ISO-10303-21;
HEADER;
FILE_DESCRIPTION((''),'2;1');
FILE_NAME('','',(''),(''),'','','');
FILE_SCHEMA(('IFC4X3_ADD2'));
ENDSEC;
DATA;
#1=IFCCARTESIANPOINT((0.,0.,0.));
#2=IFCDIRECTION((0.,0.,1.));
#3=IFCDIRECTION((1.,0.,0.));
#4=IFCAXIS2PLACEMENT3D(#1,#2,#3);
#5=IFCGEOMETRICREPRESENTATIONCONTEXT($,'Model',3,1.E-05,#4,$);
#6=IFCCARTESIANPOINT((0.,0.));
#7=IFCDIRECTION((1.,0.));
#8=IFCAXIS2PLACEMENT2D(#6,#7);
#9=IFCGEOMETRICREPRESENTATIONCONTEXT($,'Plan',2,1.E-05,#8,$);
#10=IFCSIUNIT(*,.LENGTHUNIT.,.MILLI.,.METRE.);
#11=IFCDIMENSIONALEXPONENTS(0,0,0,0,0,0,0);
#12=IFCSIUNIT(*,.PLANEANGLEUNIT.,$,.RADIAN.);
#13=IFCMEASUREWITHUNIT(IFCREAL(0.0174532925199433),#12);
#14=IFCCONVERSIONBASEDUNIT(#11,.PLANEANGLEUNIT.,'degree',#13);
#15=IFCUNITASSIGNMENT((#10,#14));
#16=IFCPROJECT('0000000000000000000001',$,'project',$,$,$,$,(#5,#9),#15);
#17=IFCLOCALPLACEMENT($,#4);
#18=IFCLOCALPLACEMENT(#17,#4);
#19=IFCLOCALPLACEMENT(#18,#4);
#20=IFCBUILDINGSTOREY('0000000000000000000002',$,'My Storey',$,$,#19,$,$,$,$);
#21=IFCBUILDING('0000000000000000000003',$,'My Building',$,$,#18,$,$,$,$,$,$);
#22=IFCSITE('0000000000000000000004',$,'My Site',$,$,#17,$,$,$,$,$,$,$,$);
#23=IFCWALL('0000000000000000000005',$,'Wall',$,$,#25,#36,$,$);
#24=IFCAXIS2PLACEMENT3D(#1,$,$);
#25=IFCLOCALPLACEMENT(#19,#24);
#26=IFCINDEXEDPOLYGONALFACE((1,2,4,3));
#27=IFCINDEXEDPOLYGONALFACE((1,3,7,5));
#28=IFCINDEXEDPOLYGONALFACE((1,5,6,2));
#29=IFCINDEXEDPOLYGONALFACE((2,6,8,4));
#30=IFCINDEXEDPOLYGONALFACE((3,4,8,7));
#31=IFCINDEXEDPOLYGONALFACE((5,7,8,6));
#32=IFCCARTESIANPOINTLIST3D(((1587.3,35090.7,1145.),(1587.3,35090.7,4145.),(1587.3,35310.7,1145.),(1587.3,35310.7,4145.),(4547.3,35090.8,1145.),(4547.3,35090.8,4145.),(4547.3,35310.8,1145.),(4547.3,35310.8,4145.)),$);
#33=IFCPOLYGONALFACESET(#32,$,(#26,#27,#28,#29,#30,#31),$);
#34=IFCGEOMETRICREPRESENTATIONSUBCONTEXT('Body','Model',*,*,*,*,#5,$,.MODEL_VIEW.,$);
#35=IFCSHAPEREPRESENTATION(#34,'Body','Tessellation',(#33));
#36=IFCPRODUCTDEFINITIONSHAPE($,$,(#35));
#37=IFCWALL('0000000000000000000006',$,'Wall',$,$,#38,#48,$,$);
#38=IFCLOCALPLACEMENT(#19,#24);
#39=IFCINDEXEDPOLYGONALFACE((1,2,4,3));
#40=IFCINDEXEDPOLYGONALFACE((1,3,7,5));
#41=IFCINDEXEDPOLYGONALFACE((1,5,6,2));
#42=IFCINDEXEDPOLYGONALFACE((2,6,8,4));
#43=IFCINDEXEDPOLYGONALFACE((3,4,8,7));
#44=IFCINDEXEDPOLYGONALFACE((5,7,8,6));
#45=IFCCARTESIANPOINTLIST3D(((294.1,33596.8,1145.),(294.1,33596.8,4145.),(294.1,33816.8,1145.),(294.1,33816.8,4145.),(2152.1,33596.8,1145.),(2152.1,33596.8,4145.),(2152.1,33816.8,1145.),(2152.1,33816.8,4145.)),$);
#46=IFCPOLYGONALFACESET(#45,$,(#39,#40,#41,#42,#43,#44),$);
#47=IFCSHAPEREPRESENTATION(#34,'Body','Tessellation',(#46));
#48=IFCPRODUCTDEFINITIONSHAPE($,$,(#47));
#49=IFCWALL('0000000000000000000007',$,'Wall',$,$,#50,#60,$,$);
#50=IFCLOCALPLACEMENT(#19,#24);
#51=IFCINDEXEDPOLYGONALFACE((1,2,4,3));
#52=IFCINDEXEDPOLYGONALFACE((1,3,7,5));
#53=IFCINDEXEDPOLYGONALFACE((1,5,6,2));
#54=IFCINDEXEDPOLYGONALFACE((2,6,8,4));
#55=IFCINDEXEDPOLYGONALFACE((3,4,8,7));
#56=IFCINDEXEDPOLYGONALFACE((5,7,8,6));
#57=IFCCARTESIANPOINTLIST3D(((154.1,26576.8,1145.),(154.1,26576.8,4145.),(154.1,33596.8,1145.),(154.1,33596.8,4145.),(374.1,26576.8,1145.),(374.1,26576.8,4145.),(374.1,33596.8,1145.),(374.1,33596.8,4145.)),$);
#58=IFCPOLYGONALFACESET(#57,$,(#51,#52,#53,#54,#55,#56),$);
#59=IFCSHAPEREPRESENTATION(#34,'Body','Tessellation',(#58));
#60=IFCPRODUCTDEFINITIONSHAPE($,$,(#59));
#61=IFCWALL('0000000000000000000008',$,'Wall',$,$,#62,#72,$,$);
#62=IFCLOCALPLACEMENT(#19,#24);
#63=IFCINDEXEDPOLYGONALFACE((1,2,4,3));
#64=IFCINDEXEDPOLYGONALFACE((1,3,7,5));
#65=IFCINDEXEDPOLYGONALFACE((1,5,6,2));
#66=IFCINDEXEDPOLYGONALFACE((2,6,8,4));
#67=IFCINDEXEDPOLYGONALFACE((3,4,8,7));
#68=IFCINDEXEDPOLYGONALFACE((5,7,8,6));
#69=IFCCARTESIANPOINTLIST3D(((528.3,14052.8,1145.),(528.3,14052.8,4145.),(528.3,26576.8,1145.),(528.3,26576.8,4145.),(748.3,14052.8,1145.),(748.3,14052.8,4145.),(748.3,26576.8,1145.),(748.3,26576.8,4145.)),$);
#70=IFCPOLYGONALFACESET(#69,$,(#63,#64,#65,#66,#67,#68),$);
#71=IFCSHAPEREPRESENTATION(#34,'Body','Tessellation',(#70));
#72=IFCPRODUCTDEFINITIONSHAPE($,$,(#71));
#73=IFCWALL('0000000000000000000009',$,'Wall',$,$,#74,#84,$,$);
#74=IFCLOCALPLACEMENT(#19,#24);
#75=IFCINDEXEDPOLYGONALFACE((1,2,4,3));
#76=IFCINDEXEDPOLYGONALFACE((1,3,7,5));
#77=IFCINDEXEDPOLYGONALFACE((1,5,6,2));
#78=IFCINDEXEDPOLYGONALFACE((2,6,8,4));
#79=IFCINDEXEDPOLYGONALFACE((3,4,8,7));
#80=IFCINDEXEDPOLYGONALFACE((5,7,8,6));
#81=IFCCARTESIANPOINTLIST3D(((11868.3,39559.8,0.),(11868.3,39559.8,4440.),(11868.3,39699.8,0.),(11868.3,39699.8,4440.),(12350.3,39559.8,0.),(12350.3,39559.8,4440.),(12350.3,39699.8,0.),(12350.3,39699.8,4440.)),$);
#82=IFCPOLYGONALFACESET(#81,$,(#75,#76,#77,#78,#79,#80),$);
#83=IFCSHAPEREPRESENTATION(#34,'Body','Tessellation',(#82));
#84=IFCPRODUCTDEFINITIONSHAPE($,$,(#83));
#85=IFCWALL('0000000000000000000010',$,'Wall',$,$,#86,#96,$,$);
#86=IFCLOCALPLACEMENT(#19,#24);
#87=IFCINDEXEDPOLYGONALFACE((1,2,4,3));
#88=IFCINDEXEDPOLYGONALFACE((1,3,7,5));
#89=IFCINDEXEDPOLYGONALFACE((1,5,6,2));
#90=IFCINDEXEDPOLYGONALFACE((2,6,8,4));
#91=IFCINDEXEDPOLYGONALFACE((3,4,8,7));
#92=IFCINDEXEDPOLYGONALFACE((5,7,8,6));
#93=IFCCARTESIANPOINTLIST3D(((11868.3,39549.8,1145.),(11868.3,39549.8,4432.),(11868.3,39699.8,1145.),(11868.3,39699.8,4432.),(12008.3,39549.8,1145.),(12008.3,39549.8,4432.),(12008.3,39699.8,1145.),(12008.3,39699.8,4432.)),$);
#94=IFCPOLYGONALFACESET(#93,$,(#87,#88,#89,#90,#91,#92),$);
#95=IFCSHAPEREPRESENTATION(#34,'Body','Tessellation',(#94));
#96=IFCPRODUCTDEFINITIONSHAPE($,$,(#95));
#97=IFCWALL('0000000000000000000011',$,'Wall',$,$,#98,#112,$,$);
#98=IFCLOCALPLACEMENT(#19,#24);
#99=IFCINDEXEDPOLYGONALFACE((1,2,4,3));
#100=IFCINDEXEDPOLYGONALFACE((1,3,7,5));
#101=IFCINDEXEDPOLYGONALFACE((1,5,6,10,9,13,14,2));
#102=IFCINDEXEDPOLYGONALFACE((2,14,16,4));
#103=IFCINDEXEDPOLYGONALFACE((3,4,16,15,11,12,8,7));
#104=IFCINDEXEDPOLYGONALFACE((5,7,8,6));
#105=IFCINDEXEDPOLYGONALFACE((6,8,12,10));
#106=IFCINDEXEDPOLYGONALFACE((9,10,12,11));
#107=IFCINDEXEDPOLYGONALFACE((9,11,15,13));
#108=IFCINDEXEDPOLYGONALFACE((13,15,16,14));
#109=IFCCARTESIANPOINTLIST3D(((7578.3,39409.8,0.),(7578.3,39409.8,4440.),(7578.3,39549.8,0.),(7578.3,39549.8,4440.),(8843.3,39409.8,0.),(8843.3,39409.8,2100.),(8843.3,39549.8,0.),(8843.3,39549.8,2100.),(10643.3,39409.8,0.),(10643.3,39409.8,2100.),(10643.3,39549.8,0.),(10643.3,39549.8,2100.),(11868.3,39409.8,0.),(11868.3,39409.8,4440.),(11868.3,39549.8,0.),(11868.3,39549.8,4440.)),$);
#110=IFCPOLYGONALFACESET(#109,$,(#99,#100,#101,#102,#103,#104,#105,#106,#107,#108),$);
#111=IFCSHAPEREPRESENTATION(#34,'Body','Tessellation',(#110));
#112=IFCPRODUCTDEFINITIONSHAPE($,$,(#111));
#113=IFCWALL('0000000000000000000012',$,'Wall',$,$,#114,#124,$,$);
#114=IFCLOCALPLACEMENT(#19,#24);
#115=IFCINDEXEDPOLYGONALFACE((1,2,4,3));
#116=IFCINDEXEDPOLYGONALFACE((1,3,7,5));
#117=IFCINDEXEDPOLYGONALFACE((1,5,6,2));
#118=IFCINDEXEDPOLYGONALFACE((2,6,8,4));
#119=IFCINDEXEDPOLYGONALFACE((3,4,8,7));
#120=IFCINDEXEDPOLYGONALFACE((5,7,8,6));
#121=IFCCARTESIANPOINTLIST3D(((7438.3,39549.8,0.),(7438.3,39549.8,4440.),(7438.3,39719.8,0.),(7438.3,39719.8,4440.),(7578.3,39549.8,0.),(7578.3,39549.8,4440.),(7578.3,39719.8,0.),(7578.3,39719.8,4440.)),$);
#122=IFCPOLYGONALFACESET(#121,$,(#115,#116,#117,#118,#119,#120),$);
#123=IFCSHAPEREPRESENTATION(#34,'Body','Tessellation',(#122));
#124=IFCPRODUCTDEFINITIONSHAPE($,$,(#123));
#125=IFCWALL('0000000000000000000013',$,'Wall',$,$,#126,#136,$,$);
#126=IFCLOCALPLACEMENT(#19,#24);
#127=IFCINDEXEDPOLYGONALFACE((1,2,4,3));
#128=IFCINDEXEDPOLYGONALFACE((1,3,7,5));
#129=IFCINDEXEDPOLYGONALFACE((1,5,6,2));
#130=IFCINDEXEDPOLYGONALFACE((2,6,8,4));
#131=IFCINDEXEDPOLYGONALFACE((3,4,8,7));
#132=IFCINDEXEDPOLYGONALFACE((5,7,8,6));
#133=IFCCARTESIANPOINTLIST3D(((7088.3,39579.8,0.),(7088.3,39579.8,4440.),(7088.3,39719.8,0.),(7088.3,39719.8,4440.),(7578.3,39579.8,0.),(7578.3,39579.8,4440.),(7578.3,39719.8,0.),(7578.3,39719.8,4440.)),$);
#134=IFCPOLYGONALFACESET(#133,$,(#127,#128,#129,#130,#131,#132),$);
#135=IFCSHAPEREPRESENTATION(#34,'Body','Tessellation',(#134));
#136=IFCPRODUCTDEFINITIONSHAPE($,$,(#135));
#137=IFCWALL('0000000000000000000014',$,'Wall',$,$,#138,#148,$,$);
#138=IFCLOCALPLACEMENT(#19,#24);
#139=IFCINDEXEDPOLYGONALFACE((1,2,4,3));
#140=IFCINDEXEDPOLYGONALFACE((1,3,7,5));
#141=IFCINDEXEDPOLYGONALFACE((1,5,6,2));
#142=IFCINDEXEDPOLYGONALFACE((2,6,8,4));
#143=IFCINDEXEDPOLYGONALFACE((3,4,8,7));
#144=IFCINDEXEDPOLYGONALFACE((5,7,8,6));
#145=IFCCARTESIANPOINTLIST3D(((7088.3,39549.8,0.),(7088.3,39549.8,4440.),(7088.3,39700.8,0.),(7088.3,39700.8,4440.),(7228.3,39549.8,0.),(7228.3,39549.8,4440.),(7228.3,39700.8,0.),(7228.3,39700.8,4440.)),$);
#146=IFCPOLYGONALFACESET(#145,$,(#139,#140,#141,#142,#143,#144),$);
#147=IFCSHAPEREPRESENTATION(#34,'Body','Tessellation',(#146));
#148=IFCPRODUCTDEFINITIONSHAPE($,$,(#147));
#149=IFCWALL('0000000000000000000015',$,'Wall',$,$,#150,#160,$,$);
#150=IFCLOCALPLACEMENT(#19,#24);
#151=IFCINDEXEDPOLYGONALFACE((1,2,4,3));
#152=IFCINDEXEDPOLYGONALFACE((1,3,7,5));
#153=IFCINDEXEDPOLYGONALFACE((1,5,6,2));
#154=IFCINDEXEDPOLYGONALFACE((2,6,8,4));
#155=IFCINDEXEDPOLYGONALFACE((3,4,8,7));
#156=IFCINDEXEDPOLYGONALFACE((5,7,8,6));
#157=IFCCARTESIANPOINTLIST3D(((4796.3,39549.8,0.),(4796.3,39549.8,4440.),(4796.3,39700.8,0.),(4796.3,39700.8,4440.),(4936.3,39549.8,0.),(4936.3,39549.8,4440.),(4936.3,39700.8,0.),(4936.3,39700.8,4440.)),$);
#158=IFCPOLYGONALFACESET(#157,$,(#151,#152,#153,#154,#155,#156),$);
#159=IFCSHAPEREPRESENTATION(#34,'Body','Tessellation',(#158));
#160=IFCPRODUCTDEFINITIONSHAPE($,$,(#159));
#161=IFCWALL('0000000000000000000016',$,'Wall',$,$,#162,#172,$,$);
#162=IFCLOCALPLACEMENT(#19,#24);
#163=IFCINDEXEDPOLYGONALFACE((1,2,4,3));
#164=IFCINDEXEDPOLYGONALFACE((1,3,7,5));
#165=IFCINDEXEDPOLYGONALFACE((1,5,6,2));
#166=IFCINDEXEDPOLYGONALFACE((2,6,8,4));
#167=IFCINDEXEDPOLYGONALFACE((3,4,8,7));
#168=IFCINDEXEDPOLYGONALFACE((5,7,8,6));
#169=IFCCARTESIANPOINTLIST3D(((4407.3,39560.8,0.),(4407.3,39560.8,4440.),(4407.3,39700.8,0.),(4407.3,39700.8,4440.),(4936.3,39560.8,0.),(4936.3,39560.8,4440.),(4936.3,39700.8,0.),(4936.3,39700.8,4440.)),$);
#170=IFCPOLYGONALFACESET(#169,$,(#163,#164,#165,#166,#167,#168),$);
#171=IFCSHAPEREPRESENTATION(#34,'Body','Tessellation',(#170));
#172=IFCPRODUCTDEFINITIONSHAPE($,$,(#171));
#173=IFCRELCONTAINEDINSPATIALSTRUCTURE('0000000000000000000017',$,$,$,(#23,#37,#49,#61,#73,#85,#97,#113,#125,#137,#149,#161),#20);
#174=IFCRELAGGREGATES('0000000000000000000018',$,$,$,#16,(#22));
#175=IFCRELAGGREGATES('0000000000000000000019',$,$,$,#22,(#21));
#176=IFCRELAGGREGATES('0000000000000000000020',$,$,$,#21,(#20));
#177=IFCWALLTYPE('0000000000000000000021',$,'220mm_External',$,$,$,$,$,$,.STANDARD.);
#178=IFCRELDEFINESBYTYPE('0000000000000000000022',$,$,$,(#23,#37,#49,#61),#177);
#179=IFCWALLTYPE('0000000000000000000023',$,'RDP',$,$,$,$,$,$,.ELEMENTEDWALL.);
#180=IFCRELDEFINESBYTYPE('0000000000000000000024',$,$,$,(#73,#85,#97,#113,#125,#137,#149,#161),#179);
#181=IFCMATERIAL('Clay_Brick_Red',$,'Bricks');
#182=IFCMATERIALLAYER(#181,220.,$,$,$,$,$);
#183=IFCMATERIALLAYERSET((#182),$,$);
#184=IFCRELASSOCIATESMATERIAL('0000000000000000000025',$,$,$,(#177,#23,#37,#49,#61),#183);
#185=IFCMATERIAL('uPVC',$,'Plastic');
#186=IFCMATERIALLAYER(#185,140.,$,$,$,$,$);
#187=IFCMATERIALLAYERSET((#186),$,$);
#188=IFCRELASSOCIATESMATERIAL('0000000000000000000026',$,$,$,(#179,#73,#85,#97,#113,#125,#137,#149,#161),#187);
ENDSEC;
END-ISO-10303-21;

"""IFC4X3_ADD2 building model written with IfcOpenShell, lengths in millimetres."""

from ifc_helpers import new_model, entity, si_unit, converted_unit, frame, origin_with_axes, origin_2d_with_axis, place, context, subcontext, project, spatial, line, indexed_curve, outline, extrude, material, layer, layer_set, layer_usage, type_object, element, save


model = new_model("IFC4X3_ADD2")

# Units and contexts
model_context = context("Model", 3, precision=1e-05, world=origin_with_axes())
plan_context = context("Plan", 2, precision=1e-05, world=origin_2d_with_axis())
body_context_1 = subcontext(model_context, "Body", "Model", "MODEL_VIEW")
ifc_project = project(units=[si_unit("LENGTHUNIT", "METRE", prefix="MILLI"), converted_unit("PLANEANGLEUNIT", "degree", entity("IfcReal", 0.0174532925199433), si_unit("PLANEANGLEUNIT", "RADIAN"), dimensions=[0, 0, 0, 0, 0, 0, 0])], contexts=[model_context, plan_context])

# Site, building, storey
site_placement = place(None, origin_with_axes())
site = spatial("IfcSite", under=ifc_project, at=site_placement, Name="My Site")
building_placement = place(site_placement, origin_with_axes())
building = spatial("IfcBuilding", under=site, at=building_placement, Name="My Building")
storey_placement = place(building_placement, origin_with_axes())
storey = spatial("IfcBuildingStorey", under=building, at=storey_placement, Name="My Storey")

# Walls
ifc_material_1 = material(Name="Clay_Brick_Red", Category="Bricks")
ifc_layer_1 = layer(ifc_material_1, 220.0)
ifc_layer_set_1 = layer_set([ifc_layer_1])
ifc_layer_usage_1 = layer_usage(ifc_layer_set_1, "AXIS2", "POSITIVE", 0.0)
wall_type_1 = type_object("IfcWallType", Name="220mm_External", PredefinedType="STANDARD", material=ifc_layer_set_1)
wall_1_placement = place(storey_placement, frame((1587.3, 35090.7, 1145.0), z_axis=(0.0, 0.0, 1.0), x_axis=(1.0, 0.000003, 0.0)))
element("IfcWall", 1, at=wall_1_placement, inside=storey, type_object=wall_type_1, material=ifc_layer_usage_1, Name="Wall", context=body_context_1, shape_type="SweptSolid", body=[
    extrude(outline(indexed_curve([(0.0, 0.0), (0.0, 220.0), (2960.0, 220.0), (2960.0, 0.0)], segments=[line(1, 2, 3, 4, 1)])), origin_with_axes(), (0.0, 0.0, 1.0), 3000.0),
])
ifc_layer_usage_2 = layer_usage(ifc_layer_set_1, "AXIS2", "POSITIVE", 0.0)
wall_2_placement = place(storey_placement, frame((294.1, 33596.8, 1145.0), z_axis=(0.0, 0.0, 1.0), x_axis=(1.0, 0.000004, 0.0)))
element("IfcWall", 2, at=wall_2_placement, inside=storey, type_object=wall_type_1, material=ifc_layer_usage_2, Name="Wall", context=body_context_1, shape_type="SweptSolid", body=[
    extrude(outline(indexed_curve([(0.0, 0.0), (0.0, 220.0), (1858.0, 220.0), (1858.0, 0.0)], segments=[line(1, 2, 3, 4, 1)])), origin_with_axes(), (0.0, 0.0, 1.0), 3000.0),
])
ifc_layer_usage_3 = layer_usage(ifc_layer_set_1, "AXIS2", "POSITIVE", 0.0)
wall_3_placement = place(storey_placement, frame((154.1, 33596.8, 1145.0), z_axis=(0.0, 0.0, 1.0), x_axis=(0.000004, -1.0, 0.0)))
element("IfcWall", 3, at=wall_3_placement, inside=storey, type_object=wall_type_1, material=ifc_layer_usage_3, Name="Wall", context=body_context_1, shape_type="SweptSolid", body=[
    extrude(outline(indexed_curve([(0.0, 0.0), (0.0, 220.0), (7020.0, 220.0), (7020.0, 0.0)], segments=[line(1, 2, 3, 4, 1)])), origin_with_axes(), (0.0, 0.0, 1.0), 3000.0),
])
ifc_layer_usage_4 = layer_usage(ifc_layer_set_1, "AXIS2", "POSITIVE", 0.0)
wall_4_placement = place(storey_placement, frame((528.3, 26576.8, 1145.0), z_axis=(0.0, 0.0, 1.0), x_axis=(0.000004, -1.0, 0.0)))
element("IfcWall", 4, at=wall_4_placement, inside=storey, type_object=wall_type_1, material=ifc_layer_usage_4, Name="Wall", context=body_context_1, shape_type="SweptSolid", body=[
    extrude(outline(indexed_curve([(0.0, 0.0), (0.0, 220.0), (12524.0, 220.0), (12524.0, 0.0)], segments=[line(1, 2, 3, 4, 1)])), origin_with_axes(), (0.0, 0.0, 1.0), 3000.0),
])
ifc_material_2 = material(Name="uPVC", Category="Plastic")
ifc_layer_2 = layer(ifc_material_2, 140.0)
ifc_layer_set_2 = layer_set([ifc_layer_2])
ifc_layer_usage_5 = layer_usage(ifc_layer_set_2, "AXIS2", "POSITIVE", 0.0)
wall_type_2 = type_object("IfcWallType", Name="RDP", PredefinedType="ELEMENTEDWALL", material=ifc_layer_set_2)
wall_5_placement = place(storey_placement, frame((11868.3, 39559.8, 0.0), z_axis=(0.0, 0.0, 1.0), x_axis=(1.0, 0.000002, 0.0)))
element("IfcWall", 5, at=wall_5_placement, inside=storey, type_object=wall_type_2, material=ifc_layer_usage_5, Name="Wall", context=body_context_1, shape_type="SweptSolid", body=[
    extrude(outline(indexed_curve([(0.0, 0.0), (0.0, 140.0), (482.0, 140.0), (482.0, 0.0)], segments=[line(1, 2, 3, 4, 1)])), origin_with_axes(), (0.0, 0.0, 1.0), 4440.0),
])
ifc_layer_usage_6 = layer_usage(ifc_layer_set_2, "AXIS2", "POSITIVE", 0.0)
wall_6_placement = place(storey_placement, frame((12008.3, 39549.8, 1145.0), z_axis=(0.0, 0.0, 1.0), x_axis=(-0.000002, 1.0, 0.0)))
element("IfcWall", 6, at=wall_6_placement, inside=storey, type_object=wall_type_2, material=ifc_layer_usage_6, Name="Wall", context=body_context_1, shape_type="SweptSolid", body=[
    extrude(outline(indexed_curve([(0.0, 0.0), (0.0, 140.0), (150.0, 140.0), (150.0, 0.0)], segments=[line(1, 2, 3, 4, 1)])), origin_with_axes(), (0.0, 0.0, 1.0), 3287.0),
])

# Wall, opening
ifc_layer_usage_7 = layer_usage(ifc_layer_set_2, "AXIS2", "POSITIVE", 0.0)
wall_7_placement = place(storey_placement, frame((11868.3, 39549.8, 0.0), z_axis=(0.0, 0.0, 1.0), x_axis=(-1.0, -0.000003, 0.0)))
wall_7 = element("IfcWall", 7, at=wall_7_placement, inside=storey, type_object=wall_type_2, material=ifc_layer_usage_7, Name="Wall", context=body_context_1, shape_type="SweptSolid", body=[
    extrude(outline(indexed_curve([(0.0, 0.0), (0.0, 140.0), (4290.0, 140.0), (4290.0, 0.0)], segments=[line(1, 2, 3, 4, 1)])), origin_with_axes(), (0.0, 0.0, 1.0), 4440.0),
])
opening_1_placement = place(wall_7_placement, frame((3025.0, 0.0, 0.0), z_axis=(0.0, 0.0, 1.0), x_axis=(-1.0, 0.000002, 0.0)))
element("IfcOpeningElement", 8, at=opening_1_placement, cuts=wall_7, PredefinedType="OPENING", context=body_context_1, shape_type="SweptSolid", body=[
    extrude(outline(indexed_curve([(0.0, 0.0), (1800.0, 0.0), (1800.0, 500.0), (0.0, 500.0), (0.0, 0.0)])), frame((0.0, -250.0, 0.0), z_axis=(0.0, 0.0, 1.0), x_axis=(1.0, 0.0, 0.0)), (0.0, 0.0, 1.0), 2100.0),
])

# Walls
ifc_layer_usage_8 = layer_usage(ifc_layer_set_2, "AXIS2", "POSITIVE", 0.0)
wall_8_placement = place(storey_placement, frame((7438.3, 39719.8, 0.0), z_axis=(0.0, 0.0, 1.0), x_axis=(0.000003, -1.0, 0.0)))
element("IfcWall", 9, at=wall_8_placement, inside=storey, type_object=wall_type_2, material=ifc_layer_usage_8, Name="Wall", context=body_context_1, shape_type="SweptSolid", body=[
    extrude(outline(indexed_curve([(0.0, 0.0), (0.0, 140.0), (170.0, 140.0), (170.0, 0.0)], segments=[line(1, 2, 3, 4, 1)])), origin_with_axes(), (0.0, 0.0, 1.0), 4440.0),
])
ifc_layer_usage_9 = layer_usage(ifc_layer_set_2, "AXIS2", "POSITIVE", 0.0)
wall_9_placement = place(storey_placement, frame((7088.3, 39579.8, 0.0), z_axis=(0.0, 0.0, 1.0), x_axis=(1.0, 0.000003, 0.0)))
element("IfcWall", 10, at=wall_9_placement, inside=storey, type_object=wall_type_2, material=ifc_layer_usage_9, Name="Wall", context=body_context_1, shape_type="SweptSolid", body=[
    extrude(outline(indexed_curve([(0.0, 0.0), (0.0, 140.0), (490.0, 140.0), (490.0, 0.0)], segments=[line(1, 2, 3, 4, 1)])), origin_with_axes(), (0.0, 0.0, 1.0), 4440.0),
])
ifc_layer_usage_10 = layer_usage(ifc_layer_set_2, "AXIS2", "POSITIVE", 0.0)
wall_10_placement = place(storey_placement, frame((7228.3, 39549.8, 0.0), z_axis=(0.0, 0.0, 1.0), x_axis=(-0.000003, 1.0, 0.0)))
element("IfcWall", 11, at=wall_10_placement, inside=storey, type_object=wall_type_2, material=ifc_layer_usage_10, Name="Wall", context=body_context_1, shape_type="SweptSolid", body=[
    extrude(outline(indexed_curve([(0.0, 0.0), (0.0, 140.0), (151.0, 140.0), (151.0, 0.0)], segments=[line(1, 2, 3, 4, 1)])), origin_with_axes(), (0.0, 0.0, 1.0), 4440.0),
])

# Walls
ifc_layer_usage_11 = layer_usage(ifc_layer_set_2, "AXIS2", "POSITIVE", 0.0)
wall_11_placement = place(storey_placement, frame((4936.3, 39549.8, 0.0), z_axis=(0.0, 0.0, 1.0), x_axis=(-0.000003, 1.0, 0.0)))
element("IfcWall", 12, at=wall_11_placement, inside=storey, type_object=wall_type_2, material=ifc_layer_usage_11, Name="Wall", context=body_context_1, shape_type="SweptSolid", body=[
    extrude(outline(indexed_curve([(0.0, 0.0), (0.0, 140.0), (151.0, 140.0), (151.0, 0.0)], segments=[line(1, 2, 3, 4, 1)])), origin_with_axes(), (0.0, 0.0, 1.0), 4440.0),
])
ifc_layer_usage_12 = layer_usage(ifc_layer_set_2, "AXIS2", "POSITIVE", 0.0)
wall_12_placement = place(storey_placement, frame((4936.3, 39700.8, 0.0), z_axis=(0.0, 0.0, 1.0), x_axis=(-1.0, -0.000003, 0.0)))
element("IfcWall", 13, at=wall_12_placement, inside=storey, type_object=wall_type_2, material=ifc_layer_usage_12, Name="Wall", context=body_context_1, shape_type="SweptSolid", body=[
    extrude(outline(indexed_curve([(0.0, 0.0), (0.0, 140.0), (529.0, 140.0), (529.0, 0.0)], segments=[line(1, 2, 3, 4, 1)])), origin_with_axes(), (0.0, 0.0, 1.0), 4440.0),
])

save(model, "model.ifc")
